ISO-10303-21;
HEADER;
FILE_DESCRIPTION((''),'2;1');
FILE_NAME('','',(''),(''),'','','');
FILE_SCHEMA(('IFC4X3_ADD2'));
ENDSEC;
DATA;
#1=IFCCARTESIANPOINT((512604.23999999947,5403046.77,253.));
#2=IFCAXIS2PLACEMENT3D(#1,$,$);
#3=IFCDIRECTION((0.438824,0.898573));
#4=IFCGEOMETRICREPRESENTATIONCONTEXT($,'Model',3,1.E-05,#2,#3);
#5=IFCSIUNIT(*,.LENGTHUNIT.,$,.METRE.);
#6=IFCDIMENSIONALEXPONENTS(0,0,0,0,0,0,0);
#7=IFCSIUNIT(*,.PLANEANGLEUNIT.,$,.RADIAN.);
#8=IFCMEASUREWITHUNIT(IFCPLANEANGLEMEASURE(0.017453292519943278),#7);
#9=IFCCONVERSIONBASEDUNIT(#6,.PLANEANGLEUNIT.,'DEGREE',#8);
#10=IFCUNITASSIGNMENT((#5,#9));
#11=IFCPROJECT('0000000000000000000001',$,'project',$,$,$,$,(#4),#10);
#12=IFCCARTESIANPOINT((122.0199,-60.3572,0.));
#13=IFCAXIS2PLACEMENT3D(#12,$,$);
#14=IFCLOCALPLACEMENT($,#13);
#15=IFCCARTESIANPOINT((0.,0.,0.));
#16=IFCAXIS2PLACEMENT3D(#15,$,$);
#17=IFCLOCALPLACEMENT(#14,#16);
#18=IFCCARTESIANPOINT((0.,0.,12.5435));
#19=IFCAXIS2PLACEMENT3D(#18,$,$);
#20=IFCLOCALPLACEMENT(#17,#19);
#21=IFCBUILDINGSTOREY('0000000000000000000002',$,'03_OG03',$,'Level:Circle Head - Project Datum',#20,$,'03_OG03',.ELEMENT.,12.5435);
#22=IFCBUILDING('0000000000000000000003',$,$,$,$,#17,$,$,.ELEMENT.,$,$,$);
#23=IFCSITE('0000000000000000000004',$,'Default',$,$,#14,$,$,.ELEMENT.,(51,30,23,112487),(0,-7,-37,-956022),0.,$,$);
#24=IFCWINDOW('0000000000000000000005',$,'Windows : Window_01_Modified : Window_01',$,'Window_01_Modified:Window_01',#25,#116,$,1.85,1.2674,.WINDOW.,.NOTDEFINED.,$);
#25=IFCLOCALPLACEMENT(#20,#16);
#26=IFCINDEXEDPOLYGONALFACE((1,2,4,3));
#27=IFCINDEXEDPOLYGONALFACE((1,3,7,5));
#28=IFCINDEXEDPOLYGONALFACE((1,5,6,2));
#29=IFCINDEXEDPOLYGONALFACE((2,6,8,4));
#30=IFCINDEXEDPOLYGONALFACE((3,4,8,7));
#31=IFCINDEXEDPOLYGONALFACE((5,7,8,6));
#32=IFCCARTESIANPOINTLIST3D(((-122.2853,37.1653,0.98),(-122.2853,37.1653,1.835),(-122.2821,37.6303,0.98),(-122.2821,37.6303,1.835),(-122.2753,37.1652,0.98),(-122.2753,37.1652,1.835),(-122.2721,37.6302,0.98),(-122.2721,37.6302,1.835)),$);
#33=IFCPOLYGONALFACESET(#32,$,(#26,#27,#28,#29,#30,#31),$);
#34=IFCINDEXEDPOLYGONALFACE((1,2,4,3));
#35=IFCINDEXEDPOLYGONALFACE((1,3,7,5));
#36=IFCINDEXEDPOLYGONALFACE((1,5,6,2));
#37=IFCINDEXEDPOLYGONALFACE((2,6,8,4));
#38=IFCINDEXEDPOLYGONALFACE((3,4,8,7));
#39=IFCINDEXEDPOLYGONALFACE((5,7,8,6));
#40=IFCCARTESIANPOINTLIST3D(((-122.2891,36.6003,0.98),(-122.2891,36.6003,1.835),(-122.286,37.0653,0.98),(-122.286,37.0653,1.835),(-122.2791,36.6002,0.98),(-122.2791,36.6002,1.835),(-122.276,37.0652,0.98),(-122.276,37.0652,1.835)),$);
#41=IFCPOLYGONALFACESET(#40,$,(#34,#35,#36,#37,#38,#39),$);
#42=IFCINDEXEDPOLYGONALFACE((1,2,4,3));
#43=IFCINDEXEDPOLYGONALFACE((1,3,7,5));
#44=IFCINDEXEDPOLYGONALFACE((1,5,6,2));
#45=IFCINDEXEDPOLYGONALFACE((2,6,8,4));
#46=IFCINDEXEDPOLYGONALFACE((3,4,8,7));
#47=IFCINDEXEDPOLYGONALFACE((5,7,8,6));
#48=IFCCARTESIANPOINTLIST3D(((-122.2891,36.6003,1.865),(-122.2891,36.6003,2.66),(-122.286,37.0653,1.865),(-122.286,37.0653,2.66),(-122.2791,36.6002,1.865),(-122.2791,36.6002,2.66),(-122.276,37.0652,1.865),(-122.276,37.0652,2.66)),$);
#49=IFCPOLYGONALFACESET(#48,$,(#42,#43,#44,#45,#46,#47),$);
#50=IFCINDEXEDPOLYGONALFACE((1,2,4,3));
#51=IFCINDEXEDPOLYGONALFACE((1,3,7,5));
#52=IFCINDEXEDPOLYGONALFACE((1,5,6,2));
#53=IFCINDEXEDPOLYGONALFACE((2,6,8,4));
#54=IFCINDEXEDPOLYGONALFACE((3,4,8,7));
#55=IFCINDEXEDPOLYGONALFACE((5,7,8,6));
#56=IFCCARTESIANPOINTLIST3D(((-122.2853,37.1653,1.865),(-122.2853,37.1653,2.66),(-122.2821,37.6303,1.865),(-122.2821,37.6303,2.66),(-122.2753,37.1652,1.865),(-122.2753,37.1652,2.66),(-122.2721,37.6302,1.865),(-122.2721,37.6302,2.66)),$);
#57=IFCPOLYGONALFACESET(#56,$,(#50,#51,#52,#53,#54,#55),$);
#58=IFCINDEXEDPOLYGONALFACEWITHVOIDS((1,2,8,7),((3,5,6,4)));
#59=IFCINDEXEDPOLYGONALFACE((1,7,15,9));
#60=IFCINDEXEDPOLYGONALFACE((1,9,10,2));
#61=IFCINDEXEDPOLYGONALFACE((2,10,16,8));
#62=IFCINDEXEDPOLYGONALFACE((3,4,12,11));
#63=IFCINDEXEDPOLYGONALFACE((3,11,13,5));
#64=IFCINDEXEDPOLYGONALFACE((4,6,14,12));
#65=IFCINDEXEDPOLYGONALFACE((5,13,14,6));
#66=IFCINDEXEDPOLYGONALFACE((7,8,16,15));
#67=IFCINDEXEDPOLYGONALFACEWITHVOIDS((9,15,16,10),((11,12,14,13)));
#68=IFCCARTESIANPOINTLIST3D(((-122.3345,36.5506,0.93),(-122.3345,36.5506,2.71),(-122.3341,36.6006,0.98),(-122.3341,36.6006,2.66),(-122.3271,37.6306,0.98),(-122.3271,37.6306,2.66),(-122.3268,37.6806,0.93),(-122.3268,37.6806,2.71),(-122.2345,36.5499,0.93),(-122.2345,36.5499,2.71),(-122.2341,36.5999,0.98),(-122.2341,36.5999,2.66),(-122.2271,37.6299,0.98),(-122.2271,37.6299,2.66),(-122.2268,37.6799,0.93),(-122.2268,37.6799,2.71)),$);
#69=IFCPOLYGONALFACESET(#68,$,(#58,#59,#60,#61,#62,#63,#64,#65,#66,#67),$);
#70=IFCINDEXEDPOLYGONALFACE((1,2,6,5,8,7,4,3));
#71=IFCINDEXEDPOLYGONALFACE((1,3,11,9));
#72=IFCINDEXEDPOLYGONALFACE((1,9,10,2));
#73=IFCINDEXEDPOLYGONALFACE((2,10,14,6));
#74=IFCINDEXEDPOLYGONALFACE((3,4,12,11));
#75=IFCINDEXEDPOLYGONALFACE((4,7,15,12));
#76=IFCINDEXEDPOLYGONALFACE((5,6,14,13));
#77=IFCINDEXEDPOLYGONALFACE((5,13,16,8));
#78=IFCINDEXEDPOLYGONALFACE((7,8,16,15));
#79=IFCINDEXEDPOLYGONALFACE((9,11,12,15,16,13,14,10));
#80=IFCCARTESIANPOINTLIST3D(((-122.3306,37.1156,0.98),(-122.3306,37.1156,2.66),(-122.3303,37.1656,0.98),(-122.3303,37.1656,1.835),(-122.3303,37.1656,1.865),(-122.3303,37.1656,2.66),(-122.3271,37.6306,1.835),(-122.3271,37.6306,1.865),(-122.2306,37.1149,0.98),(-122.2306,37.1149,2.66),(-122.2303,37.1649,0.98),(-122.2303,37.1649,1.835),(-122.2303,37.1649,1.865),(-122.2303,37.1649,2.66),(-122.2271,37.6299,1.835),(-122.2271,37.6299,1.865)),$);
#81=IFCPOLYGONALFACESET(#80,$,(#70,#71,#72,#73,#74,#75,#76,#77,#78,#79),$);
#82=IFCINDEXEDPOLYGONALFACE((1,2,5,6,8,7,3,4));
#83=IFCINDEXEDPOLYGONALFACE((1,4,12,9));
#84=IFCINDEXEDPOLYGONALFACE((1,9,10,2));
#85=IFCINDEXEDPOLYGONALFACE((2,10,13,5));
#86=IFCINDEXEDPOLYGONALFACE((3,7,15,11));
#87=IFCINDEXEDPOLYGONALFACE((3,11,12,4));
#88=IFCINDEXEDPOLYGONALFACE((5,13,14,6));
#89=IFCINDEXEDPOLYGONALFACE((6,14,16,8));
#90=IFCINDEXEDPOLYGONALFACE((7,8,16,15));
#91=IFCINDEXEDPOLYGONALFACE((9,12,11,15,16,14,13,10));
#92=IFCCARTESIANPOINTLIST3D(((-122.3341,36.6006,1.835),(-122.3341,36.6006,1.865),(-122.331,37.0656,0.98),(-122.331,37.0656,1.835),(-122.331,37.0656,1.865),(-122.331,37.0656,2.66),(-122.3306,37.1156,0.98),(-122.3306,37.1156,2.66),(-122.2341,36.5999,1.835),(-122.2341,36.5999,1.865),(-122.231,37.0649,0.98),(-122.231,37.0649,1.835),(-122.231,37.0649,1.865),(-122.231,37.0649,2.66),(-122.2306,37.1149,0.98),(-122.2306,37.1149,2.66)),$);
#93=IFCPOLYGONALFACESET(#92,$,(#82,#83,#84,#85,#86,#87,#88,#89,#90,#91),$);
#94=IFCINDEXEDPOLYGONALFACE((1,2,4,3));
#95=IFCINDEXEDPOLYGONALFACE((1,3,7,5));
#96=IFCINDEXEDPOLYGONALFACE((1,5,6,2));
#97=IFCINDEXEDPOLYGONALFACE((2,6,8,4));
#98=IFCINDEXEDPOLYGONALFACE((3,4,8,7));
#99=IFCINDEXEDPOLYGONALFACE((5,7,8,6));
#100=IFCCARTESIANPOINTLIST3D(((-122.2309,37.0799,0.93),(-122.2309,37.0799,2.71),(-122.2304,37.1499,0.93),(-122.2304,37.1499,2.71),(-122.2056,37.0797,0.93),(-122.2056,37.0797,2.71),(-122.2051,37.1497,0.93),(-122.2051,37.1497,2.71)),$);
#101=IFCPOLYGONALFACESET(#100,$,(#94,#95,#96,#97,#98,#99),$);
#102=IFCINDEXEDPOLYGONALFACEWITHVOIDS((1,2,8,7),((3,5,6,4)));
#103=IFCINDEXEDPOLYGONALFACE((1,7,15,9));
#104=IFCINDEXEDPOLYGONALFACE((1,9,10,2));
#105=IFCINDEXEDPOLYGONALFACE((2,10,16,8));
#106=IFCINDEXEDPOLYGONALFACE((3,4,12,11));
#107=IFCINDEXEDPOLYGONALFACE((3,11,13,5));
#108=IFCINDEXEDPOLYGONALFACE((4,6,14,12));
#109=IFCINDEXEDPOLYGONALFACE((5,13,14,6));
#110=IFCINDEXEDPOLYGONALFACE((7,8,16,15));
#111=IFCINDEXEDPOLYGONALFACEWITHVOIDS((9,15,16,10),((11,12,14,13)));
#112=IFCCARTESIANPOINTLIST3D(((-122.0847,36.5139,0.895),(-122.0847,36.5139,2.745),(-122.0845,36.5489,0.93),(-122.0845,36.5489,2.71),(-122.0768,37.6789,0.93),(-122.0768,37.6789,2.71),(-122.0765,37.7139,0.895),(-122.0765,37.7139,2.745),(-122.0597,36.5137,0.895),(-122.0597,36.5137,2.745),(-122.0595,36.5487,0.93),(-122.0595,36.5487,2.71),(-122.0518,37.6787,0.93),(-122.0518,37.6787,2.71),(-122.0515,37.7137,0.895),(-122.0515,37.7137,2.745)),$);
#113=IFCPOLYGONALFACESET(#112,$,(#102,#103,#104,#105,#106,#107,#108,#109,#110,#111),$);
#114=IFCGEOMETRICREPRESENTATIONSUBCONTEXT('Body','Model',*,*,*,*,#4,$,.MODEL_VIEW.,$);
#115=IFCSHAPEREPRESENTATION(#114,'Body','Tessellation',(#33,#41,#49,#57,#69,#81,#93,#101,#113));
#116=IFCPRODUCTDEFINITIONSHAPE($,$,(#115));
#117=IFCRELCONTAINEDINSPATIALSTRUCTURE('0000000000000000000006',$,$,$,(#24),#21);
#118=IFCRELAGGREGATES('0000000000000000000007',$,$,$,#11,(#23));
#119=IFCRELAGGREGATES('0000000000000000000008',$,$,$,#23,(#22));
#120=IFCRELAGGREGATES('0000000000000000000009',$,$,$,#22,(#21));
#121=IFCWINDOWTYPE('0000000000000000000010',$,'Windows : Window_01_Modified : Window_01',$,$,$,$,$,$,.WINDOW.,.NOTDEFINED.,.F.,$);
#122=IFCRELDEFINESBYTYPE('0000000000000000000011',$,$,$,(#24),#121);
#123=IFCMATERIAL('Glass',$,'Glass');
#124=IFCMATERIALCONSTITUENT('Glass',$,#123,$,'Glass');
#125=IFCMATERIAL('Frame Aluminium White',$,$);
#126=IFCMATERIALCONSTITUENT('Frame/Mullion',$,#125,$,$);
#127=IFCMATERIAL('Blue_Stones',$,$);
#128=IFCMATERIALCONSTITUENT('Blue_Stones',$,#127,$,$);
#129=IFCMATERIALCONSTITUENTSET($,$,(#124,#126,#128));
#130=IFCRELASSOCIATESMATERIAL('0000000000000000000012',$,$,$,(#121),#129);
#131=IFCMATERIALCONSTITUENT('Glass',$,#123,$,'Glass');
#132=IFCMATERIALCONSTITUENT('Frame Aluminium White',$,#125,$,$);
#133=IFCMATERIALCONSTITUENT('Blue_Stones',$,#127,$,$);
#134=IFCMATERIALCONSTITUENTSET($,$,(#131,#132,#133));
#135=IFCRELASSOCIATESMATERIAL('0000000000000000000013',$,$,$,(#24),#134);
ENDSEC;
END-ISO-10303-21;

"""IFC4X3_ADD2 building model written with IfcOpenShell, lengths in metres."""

from ifc_helpers import new_model, entity, si_unit, converted_unit, direction, frame, frame_2d, origin, place, context, subcontext, project, spatial, polyline, rectangle, outline, extrude, source, transform, mapped, material, constituent, constituent_set, type_object, type_shapes, element, save


model = new_model("IFC4X3_ADD2")

# Units and contexts
model_context = context("Model", 3, precision=1e-05, world=frame((512604.23999999947, 5403046.77, 253.0)), true_north=direction((0.438824, 0.898573)))
body_context = subcontext(model_context, "Body", "Model", "MODEL_VIEW")
ifc_project = project(units=[si_unit("LENGTHUNIT", "METRE"), converted_unit("PLANEANGLEUNIT", "DEGREE", entity("IfcPlaneAngleMeasure", 0.017453292519943278), si_unit("PLANEANGLEUNIT", "RADIAN"), dimensions=[0, 0, 0, 0, 0, 0, 0])], contexts=[model_context])

# Site, building, storey
site_placement = place(None, frame((122.0199, -60.3572, 0.0)))
site = spatial("IfcSite", under=ifc_project, at=site_placement, Name="Default", CompositionType="ELEMENT", RefLatitude=(51, 30, 23, 112487), RefLongitude=(0, -7, -37, -956022), RefElevation=0.0)
building_placement = place(site_placement, origin())
building = spatial("IfcBuilding", under=site, at=building_placement, CompositionType="ELEMENT")
storey_placement = place(building_placement, frame((0.0, 0.0, 12.5435)))
storey = spatial("IfcBuildingStorey", under=building, at=storey_placement, Name="03_OG03", ObjectType="Level:Circle Head - Project Datum", LongName="03_OG03", CompositionType="ELEMENT", Elevation=12.5435)

# Window
ifc_material_1 = material(Name="Glass", Category="Glass")
ifc_material_2 = material(Name="Frame Aluminium White")
ifc_material_3 = material(Name="Blue_Stones")
ifc_constituent_1 = constituent(ifc_material_1, Name="Glass", Category="Glass")
ifc_constituent_2 = constituent(ifc_material_2, Name="Frame Aluminium White")
ifc_constituent_3 = constituent(ifc_material_3, Name="Blue_Stones")
ifc_constituent_set_1 = constituent_set(constituents=[ifc_constituent_1, ifc_constituent_2, ifc_constituent_3])
ifc_constituent_4 = constituent(ifc_material_1, Name="Glass", Category="Glass")
ifc_constituent_5 = constituent(ifc_material_2, Name="Frame/Mullion")
ifc_constituent_6 = constituent(ifc_material_3, Name="Blue_Stones")
ifc_constituent_set_2 = constituent_set(constituents=[ifc_constituent_4, ifc_constituent_5, ifc_constituent_6])
window_type_1 = type_object("IfcWindowType", Name="Windows : Window_01_Modified : Window_01", ParameterTakesPrecedence=False, PartitioningType="NOTDEFINED", PredefinedType="WINDOW", material=ifc_constituent_set_2)
shared_shape_1 = source(origin(), body_context, "Body", "SweptSolid", [
    extrude(rectangle(XDim=0.465, YDim=0.01, at=frame_2d((0.0, 0.0), x_axis=(1.0, 0.0))), frame((0.3571, -0.2, 0.0514), z_axis=(0.0, 0.0, 1.0), x_axis=(-1.0, 0.0, 0.0)), (0.0, 0.0, 1.0), 0.855),
    extrude(rectangle(XDim=0.01, YDim=0.465, at=frame_2d((0.0, 0.0), x_axis=(1.0, 0.0))), frame((0.9221, -0.2, 0.0514), z_axis=(0.0, 0.0, 1.0), x_axis=(0.0, 1.0, 0.0)), (0.0, 0.0, 1.0), 0.855),
    extrude(rectangle(XDim=0.465, YDim=0.01, at=frame_2d((0.0, 0.0), x_axis=(1.0, 0.0))), frame((0.9221, -0.2, 0.9364), z_axis=(0.0, 0.0, 1.0), x_axis=(-1.0, 0.0, 0.0)), (0.0, 0.0, 1.0), 0.795),
    extrude(rectangle(XDim=0.465, YDim=0.01, at=frame_2d((0.0, 0.0), x_axis=(1.0, 0.0))), frame((0.3571, -0.2, 0.9364), z_axis=(0.0, 0.0, 1.0), x_axis=(-1.0, 0.0, 0.0)), (0.0, 0.0, 1.0), 0.795),
    extrude(outline(polyline([(-0.89, -0.565), (0.89, -0.565), (0.89, 0.565), (-0.89, 0.565), (-0.89, -0.565)]), holes=[polyline([(0.84, 0.515), (0.84, -0.515), (-0.84, -0.515), (-0.84, 0.515), (0.84, 0.515)])]), frame((0.6396, -0.25, 0.8914), z_axis=(0.0, 1.0, 0.0), x_axis=(0.0, 0.0, 1.0)), (0.0, 0.0, 1.0), 0.1),
    extrude(outline(polyline([(0.03, 0.1037), (0.825, 0.1037), (0.825, 0.1538), (-0.855, 0.1538), (-0.855, 0.1037), (0.0, 0.1037), (0.0, -0.3613), (0.03, -0.3613), (0.03, 0.1037)])), frame((0.4858, -0.25, 0.9064), z_axis=(0.0, 1.0, 0.0), x_axis=(0.0, 0.0, 1.0)), (0.0, 0.0, 1.0), 0.1),
    extrude(outline(polyline([(-0.825, -0.1038), (-0.825, -0.1538), (0.855, -0.1538), (0.855, -0.1038), (0.0, -0.1038), (0.0, 0.3613), (-0.03, 0.3613), (-0.03, -0.1038), (-0.825, -0.1038)])), frame((0.7933, -0.25, 0.9064), z_axis=(0.0, -1.0, 0.0), x_axis=(0.0, 0.0, -1.0)), (0.0, 0.0, -1.0), 0.1),
    extrude(rectangle(XDim=0.0253, YDim=0.07, at=frame_2d((0.0, 0.0), x_axis=(1.0, 0.0))), frame((0.6396, -0.1374, 0.0014), z_axis=(0.0, 0.0, 1.0), x_axis=(0.0, -1.0, 0.0)), (0.0, 0.0, 1.0), 1.78),
    extrude(outline(polyline([(-0.6, -0.925), (0.6, -0.925), (0.6, 0.925), (-0.6, 0.925), (-0.6, -0.925)]), holes=[polyline([(-0.565, -0.89), (-0.565, 0.89), (0.565, 0.89), (0.565, -0.89), (-0.565, -0.89)])]), frame((0.6396, 0.0, 0.8914), z_axis=(0.0, 1.0, 0.0), x_axis=(1.0, 0.0, 0.0)), (0.0, 0.0, 1.0), 0.025),
])
type_shapes(window_type_1, [shared_shape_1])
window_1_placement = place(storey_placement, frame((-122.0763, 37.7534, 0.9286), z_axis=(0.0, 0.0, 1.0), x_axis=(-0.0068, -0.999977, 0.0)))
element("IfcWindow", 1, at=window_1_placement, inside=storey, type_object=window_type_1, material=ifc_constituent_set_1, Name="Windows : Window_01_Modified : Window_01", ObjectType="Window_01_Modified:Window_01", OverallHeight=1.85, OverallWidth=1.2674, PartitioningType="NOTDEFINED", PredefinedType="WINDOW", context=body_context, shape_type="MappedRepresentation", body=[
    mapped(shared_shape_1, transform((0.0, 0.0, 0.0), scale=1.0)),
])

save(model, "model.ifc")
